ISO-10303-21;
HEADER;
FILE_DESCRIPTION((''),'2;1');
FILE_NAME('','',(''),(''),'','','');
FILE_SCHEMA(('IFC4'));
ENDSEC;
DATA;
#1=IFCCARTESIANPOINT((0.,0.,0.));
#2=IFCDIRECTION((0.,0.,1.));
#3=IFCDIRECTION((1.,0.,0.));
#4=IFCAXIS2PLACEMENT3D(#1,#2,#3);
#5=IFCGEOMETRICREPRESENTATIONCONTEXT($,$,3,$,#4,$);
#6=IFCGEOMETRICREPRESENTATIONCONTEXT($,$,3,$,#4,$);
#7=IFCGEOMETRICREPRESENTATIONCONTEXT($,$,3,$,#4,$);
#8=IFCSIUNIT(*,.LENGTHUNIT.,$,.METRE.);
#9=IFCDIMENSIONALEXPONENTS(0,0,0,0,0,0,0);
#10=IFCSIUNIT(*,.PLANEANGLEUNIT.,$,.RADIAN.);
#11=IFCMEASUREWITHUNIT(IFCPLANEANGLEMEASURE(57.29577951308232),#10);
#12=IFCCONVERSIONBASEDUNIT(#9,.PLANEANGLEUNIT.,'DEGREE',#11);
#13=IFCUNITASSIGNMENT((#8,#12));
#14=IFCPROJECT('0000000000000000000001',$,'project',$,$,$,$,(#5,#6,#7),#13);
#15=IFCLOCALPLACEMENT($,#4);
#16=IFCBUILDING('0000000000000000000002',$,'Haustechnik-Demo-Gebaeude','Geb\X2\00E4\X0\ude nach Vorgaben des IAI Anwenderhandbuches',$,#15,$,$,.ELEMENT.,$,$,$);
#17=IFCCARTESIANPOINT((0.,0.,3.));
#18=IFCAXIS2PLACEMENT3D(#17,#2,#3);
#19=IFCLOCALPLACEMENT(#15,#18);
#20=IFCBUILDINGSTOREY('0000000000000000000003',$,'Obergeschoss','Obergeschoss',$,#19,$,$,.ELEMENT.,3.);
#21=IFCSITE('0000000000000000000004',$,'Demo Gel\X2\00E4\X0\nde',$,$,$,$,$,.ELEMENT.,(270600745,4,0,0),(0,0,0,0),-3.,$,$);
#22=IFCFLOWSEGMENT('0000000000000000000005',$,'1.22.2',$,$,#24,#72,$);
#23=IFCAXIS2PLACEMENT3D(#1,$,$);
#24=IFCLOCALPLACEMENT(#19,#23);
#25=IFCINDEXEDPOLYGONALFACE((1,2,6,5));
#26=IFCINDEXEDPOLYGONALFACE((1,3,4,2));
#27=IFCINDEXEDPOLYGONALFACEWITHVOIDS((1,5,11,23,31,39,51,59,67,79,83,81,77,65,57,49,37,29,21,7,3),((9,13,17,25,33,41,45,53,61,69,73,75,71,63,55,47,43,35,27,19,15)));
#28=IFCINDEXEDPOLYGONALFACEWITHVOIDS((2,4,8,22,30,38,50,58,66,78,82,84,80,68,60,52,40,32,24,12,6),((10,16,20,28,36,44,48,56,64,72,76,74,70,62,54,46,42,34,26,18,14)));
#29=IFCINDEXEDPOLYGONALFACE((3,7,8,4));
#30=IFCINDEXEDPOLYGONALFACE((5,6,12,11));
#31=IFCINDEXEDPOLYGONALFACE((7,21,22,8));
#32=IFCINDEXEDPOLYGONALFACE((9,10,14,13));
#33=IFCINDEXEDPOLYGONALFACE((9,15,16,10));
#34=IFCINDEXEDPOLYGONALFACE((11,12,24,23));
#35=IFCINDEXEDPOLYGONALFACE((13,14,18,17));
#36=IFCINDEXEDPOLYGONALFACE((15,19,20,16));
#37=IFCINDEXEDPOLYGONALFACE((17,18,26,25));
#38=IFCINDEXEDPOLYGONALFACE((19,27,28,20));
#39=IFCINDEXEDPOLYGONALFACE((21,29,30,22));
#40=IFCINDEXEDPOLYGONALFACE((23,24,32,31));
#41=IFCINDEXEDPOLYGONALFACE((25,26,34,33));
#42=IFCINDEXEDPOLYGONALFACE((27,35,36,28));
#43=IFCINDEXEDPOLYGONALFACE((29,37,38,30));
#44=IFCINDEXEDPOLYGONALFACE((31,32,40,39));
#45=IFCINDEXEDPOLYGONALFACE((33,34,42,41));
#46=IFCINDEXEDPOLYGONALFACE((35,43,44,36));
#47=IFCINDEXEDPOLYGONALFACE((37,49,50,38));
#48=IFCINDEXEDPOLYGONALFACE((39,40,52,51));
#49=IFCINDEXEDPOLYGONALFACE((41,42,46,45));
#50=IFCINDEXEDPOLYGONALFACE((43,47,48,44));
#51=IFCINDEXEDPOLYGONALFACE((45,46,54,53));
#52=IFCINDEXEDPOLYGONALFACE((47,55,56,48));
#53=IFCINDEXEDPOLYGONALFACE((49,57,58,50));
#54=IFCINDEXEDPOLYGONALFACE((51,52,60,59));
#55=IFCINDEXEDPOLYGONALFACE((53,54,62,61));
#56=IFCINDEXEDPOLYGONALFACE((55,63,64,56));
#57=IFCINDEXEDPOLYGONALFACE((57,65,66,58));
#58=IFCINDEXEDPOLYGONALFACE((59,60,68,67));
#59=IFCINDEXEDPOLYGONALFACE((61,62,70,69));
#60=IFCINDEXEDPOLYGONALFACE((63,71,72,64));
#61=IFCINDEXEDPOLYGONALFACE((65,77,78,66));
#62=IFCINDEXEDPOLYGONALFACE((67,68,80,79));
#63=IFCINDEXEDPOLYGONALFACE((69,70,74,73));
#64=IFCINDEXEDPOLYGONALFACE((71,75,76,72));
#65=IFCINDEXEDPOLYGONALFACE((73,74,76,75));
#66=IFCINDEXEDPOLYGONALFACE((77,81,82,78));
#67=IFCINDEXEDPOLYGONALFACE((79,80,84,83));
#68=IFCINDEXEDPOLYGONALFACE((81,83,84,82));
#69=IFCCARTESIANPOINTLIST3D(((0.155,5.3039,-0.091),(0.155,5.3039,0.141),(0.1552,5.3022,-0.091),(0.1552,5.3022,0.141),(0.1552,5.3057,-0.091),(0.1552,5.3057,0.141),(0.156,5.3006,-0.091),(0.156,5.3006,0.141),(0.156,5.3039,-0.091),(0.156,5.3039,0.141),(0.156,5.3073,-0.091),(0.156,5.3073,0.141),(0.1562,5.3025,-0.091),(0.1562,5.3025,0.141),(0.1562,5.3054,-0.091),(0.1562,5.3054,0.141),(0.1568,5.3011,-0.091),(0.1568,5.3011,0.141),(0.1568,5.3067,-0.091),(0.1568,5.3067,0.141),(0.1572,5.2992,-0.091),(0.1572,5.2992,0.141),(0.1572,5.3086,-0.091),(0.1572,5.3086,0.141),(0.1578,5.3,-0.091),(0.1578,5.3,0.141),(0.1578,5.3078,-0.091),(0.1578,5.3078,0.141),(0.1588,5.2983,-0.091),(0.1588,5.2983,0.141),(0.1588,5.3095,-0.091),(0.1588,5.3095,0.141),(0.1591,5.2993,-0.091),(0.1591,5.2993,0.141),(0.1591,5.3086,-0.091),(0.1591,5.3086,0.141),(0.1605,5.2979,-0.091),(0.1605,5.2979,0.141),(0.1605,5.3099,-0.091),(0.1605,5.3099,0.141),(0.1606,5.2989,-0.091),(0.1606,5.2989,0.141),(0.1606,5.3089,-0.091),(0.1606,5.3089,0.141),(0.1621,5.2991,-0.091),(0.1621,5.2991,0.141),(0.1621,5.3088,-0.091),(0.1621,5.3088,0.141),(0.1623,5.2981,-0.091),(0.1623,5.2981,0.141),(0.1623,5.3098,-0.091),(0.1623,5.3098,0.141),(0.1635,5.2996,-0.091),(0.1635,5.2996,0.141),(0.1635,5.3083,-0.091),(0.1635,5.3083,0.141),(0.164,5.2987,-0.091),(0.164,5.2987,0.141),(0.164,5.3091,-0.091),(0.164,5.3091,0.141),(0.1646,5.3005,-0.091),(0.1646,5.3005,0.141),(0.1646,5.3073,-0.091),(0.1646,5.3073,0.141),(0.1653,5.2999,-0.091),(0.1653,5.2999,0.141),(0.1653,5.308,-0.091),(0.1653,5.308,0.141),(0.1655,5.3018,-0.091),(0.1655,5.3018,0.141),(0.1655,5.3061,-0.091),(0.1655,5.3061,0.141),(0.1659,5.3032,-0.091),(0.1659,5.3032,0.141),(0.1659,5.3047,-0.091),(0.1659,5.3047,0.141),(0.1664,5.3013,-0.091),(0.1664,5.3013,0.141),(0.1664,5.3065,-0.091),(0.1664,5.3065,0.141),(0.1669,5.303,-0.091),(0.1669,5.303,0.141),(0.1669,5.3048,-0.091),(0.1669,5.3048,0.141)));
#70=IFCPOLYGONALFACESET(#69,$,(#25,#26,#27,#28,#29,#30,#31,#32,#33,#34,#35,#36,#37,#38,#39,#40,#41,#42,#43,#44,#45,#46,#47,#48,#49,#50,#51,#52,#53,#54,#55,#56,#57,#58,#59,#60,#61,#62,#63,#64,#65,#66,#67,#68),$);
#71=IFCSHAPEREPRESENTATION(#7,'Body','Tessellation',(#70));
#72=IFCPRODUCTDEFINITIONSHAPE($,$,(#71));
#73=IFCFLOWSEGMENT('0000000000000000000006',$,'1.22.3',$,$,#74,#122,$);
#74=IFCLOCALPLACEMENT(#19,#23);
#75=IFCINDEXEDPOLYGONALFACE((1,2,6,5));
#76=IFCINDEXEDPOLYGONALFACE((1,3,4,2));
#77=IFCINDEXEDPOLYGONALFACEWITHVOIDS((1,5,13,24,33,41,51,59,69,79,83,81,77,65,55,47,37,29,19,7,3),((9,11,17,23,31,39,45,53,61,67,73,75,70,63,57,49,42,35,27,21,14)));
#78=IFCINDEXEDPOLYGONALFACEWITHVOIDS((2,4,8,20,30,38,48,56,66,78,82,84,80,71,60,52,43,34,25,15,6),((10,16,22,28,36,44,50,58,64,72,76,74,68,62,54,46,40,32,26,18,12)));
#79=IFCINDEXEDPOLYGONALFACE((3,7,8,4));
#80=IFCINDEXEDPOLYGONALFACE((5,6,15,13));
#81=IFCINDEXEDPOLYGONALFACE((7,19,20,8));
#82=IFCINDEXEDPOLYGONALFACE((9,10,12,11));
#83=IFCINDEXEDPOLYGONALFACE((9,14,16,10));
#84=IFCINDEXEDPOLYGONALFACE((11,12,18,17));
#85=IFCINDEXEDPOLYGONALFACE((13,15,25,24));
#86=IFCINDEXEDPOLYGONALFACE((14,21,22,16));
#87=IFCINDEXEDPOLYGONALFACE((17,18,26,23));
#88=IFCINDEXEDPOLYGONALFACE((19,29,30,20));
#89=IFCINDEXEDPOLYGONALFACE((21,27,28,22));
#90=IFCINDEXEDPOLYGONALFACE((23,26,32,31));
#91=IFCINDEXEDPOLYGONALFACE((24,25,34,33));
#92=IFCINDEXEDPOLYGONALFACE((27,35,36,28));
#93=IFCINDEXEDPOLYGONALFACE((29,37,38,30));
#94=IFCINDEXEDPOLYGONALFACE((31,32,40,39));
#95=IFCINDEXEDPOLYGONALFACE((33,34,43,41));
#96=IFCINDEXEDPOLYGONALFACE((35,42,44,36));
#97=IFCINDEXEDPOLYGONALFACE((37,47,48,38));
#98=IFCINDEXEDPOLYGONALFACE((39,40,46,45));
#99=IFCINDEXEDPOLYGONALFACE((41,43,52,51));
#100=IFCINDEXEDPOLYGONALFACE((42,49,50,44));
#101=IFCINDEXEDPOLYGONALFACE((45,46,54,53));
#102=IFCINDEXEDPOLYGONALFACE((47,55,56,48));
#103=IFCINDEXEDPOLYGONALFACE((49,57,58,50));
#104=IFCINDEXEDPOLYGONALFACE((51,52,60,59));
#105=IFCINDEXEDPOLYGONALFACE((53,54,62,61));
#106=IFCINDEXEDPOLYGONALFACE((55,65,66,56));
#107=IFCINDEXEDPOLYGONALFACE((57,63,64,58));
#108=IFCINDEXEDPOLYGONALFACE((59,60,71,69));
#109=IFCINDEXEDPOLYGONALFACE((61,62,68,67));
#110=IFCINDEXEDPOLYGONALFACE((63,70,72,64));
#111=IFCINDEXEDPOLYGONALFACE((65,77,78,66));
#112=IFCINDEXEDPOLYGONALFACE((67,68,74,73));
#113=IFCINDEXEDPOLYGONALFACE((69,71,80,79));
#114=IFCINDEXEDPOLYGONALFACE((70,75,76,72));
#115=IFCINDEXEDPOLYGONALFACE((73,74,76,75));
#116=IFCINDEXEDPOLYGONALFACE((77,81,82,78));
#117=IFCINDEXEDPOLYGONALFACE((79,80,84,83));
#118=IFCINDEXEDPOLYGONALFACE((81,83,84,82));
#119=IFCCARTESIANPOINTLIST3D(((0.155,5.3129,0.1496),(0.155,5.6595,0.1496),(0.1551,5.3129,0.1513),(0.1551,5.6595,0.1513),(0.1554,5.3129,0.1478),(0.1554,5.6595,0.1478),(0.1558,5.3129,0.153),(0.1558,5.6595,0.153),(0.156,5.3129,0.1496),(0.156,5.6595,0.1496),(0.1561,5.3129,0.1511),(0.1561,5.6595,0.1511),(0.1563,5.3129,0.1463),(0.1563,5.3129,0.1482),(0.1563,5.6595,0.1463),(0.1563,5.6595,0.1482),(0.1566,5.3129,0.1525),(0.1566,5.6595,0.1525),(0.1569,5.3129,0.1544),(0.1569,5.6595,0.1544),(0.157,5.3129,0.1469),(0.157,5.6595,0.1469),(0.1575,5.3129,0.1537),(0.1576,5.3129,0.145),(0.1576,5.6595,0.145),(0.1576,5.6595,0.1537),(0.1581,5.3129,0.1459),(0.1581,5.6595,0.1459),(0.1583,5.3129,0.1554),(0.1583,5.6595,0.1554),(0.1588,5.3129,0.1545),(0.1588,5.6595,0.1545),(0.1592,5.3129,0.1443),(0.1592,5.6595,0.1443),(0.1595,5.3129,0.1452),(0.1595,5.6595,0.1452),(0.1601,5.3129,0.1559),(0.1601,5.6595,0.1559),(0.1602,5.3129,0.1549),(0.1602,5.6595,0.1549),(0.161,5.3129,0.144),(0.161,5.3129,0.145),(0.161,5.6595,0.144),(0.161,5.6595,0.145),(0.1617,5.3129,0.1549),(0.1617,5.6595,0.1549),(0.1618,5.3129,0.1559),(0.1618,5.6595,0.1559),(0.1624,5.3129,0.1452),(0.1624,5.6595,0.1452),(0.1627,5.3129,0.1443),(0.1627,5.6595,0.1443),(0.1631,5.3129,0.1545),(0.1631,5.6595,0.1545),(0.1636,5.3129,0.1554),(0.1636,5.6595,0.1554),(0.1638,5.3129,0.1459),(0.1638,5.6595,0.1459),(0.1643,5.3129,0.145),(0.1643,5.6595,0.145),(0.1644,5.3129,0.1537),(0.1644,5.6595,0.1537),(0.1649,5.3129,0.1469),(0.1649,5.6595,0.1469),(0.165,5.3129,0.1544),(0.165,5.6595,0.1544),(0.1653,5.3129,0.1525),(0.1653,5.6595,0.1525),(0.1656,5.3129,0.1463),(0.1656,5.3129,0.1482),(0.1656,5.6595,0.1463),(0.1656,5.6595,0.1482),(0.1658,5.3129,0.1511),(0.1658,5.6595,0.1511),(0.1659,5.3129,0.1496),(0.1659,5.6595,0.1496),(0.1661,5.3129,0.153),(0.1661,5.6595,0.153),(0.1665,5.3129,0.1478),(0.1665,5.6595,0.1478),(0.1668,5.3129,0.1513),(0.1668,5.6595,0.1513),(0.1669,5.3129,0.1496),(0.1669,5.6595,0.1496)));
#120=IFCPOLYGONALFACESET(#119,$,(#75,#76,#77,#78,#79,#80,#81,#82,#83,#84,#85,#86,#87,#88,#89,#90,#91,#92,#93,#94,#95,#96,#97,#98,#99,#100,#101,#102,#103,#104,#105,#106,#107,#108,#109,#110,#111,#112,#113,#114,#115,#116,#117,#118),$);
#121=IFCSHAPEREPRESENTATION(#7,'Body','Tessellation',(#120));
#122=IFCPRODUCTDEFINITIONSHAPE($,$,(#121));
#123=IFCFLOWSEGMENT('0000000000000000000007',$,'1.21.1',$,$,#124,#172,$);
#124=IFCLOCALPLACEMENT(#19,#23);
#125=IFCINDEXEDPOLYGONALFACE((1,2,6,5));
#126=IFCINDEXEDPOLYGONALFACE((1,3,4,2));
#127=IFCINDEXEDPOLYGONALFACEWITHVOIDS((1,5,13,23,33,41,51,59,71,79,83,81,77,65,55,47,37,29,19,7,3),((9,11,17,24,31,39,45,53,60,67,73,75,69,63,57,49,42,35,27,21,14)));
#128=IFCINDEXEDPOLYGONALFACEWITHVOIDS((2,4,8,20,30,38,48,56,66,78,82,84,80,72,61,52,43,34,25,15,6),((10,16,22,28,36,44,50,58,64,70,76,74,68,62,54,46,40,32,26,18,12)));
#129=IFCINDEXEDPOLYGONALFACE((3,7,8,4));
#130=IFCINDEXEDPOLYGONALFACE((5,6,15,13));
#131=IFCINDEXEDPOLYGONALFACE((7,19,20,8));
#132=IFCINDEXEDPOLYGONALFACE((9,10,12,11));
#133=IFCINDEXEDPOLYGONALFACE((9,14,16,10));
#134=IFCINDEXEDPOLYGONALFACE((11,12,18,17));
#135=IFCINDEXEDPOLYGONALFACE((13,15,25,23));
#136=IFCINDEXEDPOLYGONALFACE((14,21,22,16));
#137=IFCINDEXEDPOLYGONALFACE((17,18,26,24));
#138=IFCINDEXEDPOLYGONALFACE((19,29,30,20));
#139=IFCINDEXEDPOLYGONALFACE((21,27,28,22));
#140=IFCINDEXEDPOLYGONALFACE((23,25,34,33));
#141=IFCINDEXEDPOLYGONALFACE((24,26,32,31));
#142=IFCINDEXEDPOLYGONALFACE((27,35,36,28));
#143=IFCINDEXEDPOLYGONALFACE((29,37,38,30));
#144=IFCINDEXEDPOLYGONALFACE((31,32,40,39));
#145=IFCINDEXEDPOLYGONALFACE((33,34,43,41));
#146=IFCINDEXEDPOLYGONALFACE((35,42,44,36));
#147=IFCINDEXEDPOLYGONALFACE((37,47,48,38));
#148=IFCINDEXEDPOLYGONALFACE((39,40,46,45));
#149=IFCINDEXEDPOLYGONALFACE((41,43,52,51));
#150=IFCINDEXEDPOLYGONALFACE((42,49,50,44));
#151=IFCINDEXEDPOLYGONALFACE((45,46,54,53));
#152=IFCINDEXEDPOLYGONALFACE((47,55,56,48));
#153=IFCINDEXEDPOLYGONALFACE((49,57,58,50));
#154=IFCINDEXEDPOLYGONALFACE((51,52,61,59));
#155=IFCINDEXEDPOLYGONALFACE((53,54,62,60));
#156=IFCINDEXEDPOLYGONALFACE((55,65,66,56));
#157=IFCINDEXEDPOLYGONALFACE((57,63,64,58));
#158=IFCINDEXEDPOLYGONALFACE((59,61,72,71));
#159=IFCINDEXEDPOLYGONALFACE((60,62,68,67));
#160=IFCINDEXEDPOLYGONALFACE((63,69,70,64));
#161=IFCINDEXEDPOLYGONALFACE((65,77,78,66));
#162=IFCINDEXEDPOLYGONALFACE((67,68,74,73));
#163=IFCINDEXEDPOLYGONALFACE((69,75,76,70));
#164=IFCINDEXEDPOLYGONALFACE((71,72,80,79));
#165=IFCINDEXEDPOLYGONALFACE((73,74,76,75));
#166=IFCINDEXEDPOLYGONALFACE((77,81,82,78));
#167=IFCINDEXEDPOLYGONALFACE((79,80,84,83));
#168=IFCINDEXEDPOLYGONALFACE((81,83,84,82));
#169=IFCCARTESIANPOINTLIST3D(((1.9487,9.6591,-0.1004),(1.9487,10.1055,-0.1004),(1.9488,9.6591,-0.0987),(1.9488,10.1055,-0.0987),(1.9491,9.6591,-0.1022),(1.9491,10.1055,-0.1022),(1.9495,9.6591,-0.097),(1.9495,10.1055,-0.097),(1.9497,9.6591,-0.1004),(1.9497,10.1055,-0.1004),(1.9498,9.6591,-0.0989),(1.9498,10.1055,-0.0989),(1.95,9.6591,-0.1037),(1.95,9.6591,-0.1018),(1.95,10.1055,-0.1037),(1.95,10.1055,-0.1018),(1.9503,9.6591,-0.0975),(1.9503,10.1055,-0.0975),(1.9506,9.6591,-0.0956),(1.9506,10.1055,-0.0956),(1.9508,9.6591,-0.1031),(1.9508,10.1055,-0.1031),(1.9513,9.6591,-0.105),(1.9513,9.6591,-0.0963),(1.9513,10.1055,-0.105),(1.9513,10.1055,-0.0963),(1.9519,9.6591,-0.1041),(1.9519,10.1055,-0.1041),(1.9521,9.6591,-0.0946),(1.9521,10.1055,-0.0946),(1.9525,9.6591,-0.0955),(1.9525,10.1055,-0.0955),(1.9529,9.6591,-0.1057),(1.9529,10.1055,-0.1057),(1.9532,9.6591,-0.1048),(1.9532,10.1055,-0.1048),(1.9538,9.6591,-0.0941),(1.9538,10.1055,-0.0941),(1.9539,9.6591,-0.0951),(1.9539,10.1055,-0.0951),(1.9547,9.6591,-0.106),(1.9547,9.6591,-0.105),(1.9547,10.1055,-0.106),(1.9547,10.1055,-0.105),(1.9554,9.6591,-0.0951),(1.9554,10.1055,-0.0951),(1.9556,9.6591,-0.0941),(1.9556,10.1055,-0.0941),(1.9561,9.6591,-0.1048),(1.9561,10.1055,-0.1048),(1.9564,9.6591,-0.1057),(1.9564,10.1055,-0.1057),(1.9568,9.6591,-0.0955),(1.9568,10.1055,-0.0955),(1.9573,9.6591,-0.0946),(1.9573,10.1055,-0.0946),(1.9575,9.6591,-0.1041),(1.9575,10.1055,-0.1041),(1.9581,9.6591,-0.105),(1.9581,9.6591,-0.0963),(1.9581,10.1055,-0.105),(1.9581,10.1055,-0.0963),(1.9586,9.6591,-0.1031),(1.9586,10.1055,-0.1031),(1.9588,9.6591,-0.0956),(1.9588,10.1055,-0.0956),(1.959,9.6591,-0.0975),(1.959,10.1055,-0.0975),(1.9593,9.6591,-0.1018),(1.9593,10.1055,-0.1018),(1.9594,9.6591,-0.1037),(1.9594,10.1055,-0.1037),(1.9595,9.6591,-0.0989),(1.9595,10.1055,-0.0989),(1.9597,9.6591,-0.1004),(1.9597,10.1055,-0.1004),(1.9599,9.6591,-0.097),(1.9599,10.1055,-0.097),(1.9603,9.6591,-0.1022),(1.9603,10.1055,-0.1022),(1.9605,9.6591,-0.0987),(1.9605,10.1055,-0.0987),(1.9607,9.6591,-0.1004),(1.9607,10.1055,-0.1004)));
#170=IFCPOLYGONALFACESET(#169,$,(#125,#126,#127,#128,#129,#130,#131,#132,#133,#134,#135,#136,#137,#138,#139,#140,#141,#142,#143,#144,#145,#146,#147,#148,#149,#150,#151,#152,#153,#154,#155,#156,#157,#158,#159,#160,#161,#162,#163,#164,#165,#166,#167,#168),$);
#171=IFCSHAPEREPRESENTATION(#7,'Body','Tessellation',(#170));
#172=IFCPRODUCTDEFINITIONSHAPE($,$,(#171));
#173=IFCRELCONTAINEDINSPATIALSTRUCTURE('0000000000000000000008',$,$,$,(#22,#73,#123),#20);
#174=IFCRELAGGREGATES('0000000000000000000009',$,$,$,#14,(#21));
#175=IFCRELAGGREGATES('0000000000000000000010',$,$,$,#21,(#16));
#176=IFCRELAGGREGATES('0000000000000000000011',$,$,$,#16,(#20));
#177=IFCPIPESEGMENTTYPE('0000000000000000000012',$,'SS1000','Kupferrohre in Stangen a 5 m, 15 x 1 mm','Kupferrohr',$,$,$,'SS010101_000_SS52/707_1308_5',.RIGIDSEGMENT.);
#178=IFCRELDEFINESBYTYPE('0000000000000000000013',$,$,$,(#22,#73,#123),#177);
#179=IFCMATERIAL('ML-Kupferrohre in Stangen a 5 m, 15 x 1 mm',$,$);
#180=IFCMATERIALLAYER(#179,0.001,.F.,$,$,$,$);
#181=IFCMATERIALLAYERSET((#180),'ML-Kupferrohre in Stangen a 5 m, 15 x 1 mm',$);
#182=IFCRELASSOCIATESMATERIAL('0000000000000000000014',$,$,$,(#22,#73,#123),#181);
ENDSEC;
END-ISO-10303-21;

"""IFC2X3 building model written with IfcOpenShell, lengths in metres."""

from ifc_helpers import new_model, entity, si_unit, converted_unit, frame, origin_with_axes, origin_2d_with_axis, place, context, project, spatial, hollow_circle, extrude, material, layer, layer_set, layer_usage, type_object, element, save


model = new_model("IFC2X3")

# Units and contexts
context_of_model_1 = context(None, 3, world=origin_with_axes())
context_of_model_2 = context(None, 3, world=origin_with_axes())
context_of_model_3 = context(None, 3, world=origin_with_axes())
ifc_project = project(units=[si_unit("LENGTHUNIT", "METRE"), converted_unit("PLANEANGLEUNIT", "DEGREE", entity("IfcPlaneAngleMeasure", 57.29577951308232), si_unit("PLANEANGLEUNIT", "RADIAN"), dimensions=[0, 0, 0, 0, 0, 0, 0])], contexts=[context_of_model_1, context_of_model_2, context_of_model_3])

# Site, building, storey
site = spatial("IfcSite", under=ifc_project, Name="Demo Gelände", CompositionType="ELEMENT", RefLatitude=(270600745, 4, 0, 0), RefLongitude=(0, 0, 0, 0), RefElevation=-3.0)
building_placement = place(None, origin_with_axes())
building = spatial("IfcBuilding", under=site, at=building_placement, Name="Haustechnik-Demo-Gebaeude", Description="Gebäude nach Vorgaben des IAI Anwenderhandbuches", CompositionType="ELEMENT")
storey_placement = place(building_placement, frame((0.0, 0.0, 3.0), z_axis=(0.0, 0.0, 1.0), x_axis=(1.0, 0.0, 0.0)))
storey = spatial("IfcBuildingStorey", under=building, at=storey_placement, Name="Obergeschoss", Description="Obergeschoss", CompositionType="ELEMENT", Elevation=3.0)

# Flow segments
ifc_material = material(Name="ML-Kupferrohre in Stangen a 5 m, 15 x 1 mm")
ifc_layer = layer(ifc_material, 0.001, ventilated=False)
ifc_layer_set = layer_set([ifc_layer], Name="ML-Kupferrohre in Stangen a 5 m, 15 x 1 mm")
ifc_layer_usage = layer_usage(ifc_layer_set, "AXIS2", "POSITIVE", 0.0)
pipe_segment_type_1 = type_object("IfcPipeSegmentType", Name="SS1000", Description="Kupferrohre in Stangen a 5 m, 15 x 1 mm", ApplicableOccurrence="Kupferrohr", ElementType="SS010101_000_SS52/707_1308_5", PredefinedType="RIGIDSEGMENT")
flow_segment_1_placement = place(storey_placement, frame((0.161, 5.3039, -0.091), z_axis=(0.0, 0.0, 1.0), x_axis=(-1.0, 0.0, 0.0)))
element("IfcFlowSegment", 1, at=flow_segment_1_placement, inside=storey, type_object=pipe_segment_type_1, material=ifc_layer_usage, Name="1.22.2", context=context_of_model_3, shape_type="SweptSolid", body=[
    extrude(hollow_circle(Radius=0.006, WallThickness=0.001, at=origin_2d_with_axis()), origin_with_axes(), (0.0, 0.0, 1.0), 0.232),
])
flow_segment_2_placement = place(storey_placement, frame((0.161, 5.3129, 0.15), z_axis=(0.000002, 1.0, 0.0), x_axis=(0.0, 0.0, -1.0)))
element("IfcFlowSegment", 2, at=flow_segment_2_placement, inside=storey, type_object=pipe_segment_type_1, material=ifc_layer_usage, Name="1.22.3", context=context_of_model_3, shape_type="SweptSolid", body=[
    extrude(hollow_circle(Radius=0.006, WallThickness=0.001, at=origin_2d_with_axis()), origin_with_axes(), (0.0, 0.0, 1.0), 0.3466),
])
flow_segment_3_placement = place(storey_placement, frame((1.9547, 9.6591, -0.1), z_axis=(0.0, 1.0, 0.0), x_axis=(0.0, 0.0, -1.0)))
element("IfcFlowSegment", 3, at=flow_segment_3_placement, inside=storey, type_object=pipe_segment_type_1, material=ifc_layer_usage, Name="1.21.1", context=context_of_model_3, shape_type="SweptSolid", body=[
    extrude(hollow_circle(Radius=0.006, WallThickness=0.001, at=origin_2d_with_axis()), origin_with_axes(), (0.0, 0.0, 1.0), 0.4464),
])

save(model, "model.ifc")
